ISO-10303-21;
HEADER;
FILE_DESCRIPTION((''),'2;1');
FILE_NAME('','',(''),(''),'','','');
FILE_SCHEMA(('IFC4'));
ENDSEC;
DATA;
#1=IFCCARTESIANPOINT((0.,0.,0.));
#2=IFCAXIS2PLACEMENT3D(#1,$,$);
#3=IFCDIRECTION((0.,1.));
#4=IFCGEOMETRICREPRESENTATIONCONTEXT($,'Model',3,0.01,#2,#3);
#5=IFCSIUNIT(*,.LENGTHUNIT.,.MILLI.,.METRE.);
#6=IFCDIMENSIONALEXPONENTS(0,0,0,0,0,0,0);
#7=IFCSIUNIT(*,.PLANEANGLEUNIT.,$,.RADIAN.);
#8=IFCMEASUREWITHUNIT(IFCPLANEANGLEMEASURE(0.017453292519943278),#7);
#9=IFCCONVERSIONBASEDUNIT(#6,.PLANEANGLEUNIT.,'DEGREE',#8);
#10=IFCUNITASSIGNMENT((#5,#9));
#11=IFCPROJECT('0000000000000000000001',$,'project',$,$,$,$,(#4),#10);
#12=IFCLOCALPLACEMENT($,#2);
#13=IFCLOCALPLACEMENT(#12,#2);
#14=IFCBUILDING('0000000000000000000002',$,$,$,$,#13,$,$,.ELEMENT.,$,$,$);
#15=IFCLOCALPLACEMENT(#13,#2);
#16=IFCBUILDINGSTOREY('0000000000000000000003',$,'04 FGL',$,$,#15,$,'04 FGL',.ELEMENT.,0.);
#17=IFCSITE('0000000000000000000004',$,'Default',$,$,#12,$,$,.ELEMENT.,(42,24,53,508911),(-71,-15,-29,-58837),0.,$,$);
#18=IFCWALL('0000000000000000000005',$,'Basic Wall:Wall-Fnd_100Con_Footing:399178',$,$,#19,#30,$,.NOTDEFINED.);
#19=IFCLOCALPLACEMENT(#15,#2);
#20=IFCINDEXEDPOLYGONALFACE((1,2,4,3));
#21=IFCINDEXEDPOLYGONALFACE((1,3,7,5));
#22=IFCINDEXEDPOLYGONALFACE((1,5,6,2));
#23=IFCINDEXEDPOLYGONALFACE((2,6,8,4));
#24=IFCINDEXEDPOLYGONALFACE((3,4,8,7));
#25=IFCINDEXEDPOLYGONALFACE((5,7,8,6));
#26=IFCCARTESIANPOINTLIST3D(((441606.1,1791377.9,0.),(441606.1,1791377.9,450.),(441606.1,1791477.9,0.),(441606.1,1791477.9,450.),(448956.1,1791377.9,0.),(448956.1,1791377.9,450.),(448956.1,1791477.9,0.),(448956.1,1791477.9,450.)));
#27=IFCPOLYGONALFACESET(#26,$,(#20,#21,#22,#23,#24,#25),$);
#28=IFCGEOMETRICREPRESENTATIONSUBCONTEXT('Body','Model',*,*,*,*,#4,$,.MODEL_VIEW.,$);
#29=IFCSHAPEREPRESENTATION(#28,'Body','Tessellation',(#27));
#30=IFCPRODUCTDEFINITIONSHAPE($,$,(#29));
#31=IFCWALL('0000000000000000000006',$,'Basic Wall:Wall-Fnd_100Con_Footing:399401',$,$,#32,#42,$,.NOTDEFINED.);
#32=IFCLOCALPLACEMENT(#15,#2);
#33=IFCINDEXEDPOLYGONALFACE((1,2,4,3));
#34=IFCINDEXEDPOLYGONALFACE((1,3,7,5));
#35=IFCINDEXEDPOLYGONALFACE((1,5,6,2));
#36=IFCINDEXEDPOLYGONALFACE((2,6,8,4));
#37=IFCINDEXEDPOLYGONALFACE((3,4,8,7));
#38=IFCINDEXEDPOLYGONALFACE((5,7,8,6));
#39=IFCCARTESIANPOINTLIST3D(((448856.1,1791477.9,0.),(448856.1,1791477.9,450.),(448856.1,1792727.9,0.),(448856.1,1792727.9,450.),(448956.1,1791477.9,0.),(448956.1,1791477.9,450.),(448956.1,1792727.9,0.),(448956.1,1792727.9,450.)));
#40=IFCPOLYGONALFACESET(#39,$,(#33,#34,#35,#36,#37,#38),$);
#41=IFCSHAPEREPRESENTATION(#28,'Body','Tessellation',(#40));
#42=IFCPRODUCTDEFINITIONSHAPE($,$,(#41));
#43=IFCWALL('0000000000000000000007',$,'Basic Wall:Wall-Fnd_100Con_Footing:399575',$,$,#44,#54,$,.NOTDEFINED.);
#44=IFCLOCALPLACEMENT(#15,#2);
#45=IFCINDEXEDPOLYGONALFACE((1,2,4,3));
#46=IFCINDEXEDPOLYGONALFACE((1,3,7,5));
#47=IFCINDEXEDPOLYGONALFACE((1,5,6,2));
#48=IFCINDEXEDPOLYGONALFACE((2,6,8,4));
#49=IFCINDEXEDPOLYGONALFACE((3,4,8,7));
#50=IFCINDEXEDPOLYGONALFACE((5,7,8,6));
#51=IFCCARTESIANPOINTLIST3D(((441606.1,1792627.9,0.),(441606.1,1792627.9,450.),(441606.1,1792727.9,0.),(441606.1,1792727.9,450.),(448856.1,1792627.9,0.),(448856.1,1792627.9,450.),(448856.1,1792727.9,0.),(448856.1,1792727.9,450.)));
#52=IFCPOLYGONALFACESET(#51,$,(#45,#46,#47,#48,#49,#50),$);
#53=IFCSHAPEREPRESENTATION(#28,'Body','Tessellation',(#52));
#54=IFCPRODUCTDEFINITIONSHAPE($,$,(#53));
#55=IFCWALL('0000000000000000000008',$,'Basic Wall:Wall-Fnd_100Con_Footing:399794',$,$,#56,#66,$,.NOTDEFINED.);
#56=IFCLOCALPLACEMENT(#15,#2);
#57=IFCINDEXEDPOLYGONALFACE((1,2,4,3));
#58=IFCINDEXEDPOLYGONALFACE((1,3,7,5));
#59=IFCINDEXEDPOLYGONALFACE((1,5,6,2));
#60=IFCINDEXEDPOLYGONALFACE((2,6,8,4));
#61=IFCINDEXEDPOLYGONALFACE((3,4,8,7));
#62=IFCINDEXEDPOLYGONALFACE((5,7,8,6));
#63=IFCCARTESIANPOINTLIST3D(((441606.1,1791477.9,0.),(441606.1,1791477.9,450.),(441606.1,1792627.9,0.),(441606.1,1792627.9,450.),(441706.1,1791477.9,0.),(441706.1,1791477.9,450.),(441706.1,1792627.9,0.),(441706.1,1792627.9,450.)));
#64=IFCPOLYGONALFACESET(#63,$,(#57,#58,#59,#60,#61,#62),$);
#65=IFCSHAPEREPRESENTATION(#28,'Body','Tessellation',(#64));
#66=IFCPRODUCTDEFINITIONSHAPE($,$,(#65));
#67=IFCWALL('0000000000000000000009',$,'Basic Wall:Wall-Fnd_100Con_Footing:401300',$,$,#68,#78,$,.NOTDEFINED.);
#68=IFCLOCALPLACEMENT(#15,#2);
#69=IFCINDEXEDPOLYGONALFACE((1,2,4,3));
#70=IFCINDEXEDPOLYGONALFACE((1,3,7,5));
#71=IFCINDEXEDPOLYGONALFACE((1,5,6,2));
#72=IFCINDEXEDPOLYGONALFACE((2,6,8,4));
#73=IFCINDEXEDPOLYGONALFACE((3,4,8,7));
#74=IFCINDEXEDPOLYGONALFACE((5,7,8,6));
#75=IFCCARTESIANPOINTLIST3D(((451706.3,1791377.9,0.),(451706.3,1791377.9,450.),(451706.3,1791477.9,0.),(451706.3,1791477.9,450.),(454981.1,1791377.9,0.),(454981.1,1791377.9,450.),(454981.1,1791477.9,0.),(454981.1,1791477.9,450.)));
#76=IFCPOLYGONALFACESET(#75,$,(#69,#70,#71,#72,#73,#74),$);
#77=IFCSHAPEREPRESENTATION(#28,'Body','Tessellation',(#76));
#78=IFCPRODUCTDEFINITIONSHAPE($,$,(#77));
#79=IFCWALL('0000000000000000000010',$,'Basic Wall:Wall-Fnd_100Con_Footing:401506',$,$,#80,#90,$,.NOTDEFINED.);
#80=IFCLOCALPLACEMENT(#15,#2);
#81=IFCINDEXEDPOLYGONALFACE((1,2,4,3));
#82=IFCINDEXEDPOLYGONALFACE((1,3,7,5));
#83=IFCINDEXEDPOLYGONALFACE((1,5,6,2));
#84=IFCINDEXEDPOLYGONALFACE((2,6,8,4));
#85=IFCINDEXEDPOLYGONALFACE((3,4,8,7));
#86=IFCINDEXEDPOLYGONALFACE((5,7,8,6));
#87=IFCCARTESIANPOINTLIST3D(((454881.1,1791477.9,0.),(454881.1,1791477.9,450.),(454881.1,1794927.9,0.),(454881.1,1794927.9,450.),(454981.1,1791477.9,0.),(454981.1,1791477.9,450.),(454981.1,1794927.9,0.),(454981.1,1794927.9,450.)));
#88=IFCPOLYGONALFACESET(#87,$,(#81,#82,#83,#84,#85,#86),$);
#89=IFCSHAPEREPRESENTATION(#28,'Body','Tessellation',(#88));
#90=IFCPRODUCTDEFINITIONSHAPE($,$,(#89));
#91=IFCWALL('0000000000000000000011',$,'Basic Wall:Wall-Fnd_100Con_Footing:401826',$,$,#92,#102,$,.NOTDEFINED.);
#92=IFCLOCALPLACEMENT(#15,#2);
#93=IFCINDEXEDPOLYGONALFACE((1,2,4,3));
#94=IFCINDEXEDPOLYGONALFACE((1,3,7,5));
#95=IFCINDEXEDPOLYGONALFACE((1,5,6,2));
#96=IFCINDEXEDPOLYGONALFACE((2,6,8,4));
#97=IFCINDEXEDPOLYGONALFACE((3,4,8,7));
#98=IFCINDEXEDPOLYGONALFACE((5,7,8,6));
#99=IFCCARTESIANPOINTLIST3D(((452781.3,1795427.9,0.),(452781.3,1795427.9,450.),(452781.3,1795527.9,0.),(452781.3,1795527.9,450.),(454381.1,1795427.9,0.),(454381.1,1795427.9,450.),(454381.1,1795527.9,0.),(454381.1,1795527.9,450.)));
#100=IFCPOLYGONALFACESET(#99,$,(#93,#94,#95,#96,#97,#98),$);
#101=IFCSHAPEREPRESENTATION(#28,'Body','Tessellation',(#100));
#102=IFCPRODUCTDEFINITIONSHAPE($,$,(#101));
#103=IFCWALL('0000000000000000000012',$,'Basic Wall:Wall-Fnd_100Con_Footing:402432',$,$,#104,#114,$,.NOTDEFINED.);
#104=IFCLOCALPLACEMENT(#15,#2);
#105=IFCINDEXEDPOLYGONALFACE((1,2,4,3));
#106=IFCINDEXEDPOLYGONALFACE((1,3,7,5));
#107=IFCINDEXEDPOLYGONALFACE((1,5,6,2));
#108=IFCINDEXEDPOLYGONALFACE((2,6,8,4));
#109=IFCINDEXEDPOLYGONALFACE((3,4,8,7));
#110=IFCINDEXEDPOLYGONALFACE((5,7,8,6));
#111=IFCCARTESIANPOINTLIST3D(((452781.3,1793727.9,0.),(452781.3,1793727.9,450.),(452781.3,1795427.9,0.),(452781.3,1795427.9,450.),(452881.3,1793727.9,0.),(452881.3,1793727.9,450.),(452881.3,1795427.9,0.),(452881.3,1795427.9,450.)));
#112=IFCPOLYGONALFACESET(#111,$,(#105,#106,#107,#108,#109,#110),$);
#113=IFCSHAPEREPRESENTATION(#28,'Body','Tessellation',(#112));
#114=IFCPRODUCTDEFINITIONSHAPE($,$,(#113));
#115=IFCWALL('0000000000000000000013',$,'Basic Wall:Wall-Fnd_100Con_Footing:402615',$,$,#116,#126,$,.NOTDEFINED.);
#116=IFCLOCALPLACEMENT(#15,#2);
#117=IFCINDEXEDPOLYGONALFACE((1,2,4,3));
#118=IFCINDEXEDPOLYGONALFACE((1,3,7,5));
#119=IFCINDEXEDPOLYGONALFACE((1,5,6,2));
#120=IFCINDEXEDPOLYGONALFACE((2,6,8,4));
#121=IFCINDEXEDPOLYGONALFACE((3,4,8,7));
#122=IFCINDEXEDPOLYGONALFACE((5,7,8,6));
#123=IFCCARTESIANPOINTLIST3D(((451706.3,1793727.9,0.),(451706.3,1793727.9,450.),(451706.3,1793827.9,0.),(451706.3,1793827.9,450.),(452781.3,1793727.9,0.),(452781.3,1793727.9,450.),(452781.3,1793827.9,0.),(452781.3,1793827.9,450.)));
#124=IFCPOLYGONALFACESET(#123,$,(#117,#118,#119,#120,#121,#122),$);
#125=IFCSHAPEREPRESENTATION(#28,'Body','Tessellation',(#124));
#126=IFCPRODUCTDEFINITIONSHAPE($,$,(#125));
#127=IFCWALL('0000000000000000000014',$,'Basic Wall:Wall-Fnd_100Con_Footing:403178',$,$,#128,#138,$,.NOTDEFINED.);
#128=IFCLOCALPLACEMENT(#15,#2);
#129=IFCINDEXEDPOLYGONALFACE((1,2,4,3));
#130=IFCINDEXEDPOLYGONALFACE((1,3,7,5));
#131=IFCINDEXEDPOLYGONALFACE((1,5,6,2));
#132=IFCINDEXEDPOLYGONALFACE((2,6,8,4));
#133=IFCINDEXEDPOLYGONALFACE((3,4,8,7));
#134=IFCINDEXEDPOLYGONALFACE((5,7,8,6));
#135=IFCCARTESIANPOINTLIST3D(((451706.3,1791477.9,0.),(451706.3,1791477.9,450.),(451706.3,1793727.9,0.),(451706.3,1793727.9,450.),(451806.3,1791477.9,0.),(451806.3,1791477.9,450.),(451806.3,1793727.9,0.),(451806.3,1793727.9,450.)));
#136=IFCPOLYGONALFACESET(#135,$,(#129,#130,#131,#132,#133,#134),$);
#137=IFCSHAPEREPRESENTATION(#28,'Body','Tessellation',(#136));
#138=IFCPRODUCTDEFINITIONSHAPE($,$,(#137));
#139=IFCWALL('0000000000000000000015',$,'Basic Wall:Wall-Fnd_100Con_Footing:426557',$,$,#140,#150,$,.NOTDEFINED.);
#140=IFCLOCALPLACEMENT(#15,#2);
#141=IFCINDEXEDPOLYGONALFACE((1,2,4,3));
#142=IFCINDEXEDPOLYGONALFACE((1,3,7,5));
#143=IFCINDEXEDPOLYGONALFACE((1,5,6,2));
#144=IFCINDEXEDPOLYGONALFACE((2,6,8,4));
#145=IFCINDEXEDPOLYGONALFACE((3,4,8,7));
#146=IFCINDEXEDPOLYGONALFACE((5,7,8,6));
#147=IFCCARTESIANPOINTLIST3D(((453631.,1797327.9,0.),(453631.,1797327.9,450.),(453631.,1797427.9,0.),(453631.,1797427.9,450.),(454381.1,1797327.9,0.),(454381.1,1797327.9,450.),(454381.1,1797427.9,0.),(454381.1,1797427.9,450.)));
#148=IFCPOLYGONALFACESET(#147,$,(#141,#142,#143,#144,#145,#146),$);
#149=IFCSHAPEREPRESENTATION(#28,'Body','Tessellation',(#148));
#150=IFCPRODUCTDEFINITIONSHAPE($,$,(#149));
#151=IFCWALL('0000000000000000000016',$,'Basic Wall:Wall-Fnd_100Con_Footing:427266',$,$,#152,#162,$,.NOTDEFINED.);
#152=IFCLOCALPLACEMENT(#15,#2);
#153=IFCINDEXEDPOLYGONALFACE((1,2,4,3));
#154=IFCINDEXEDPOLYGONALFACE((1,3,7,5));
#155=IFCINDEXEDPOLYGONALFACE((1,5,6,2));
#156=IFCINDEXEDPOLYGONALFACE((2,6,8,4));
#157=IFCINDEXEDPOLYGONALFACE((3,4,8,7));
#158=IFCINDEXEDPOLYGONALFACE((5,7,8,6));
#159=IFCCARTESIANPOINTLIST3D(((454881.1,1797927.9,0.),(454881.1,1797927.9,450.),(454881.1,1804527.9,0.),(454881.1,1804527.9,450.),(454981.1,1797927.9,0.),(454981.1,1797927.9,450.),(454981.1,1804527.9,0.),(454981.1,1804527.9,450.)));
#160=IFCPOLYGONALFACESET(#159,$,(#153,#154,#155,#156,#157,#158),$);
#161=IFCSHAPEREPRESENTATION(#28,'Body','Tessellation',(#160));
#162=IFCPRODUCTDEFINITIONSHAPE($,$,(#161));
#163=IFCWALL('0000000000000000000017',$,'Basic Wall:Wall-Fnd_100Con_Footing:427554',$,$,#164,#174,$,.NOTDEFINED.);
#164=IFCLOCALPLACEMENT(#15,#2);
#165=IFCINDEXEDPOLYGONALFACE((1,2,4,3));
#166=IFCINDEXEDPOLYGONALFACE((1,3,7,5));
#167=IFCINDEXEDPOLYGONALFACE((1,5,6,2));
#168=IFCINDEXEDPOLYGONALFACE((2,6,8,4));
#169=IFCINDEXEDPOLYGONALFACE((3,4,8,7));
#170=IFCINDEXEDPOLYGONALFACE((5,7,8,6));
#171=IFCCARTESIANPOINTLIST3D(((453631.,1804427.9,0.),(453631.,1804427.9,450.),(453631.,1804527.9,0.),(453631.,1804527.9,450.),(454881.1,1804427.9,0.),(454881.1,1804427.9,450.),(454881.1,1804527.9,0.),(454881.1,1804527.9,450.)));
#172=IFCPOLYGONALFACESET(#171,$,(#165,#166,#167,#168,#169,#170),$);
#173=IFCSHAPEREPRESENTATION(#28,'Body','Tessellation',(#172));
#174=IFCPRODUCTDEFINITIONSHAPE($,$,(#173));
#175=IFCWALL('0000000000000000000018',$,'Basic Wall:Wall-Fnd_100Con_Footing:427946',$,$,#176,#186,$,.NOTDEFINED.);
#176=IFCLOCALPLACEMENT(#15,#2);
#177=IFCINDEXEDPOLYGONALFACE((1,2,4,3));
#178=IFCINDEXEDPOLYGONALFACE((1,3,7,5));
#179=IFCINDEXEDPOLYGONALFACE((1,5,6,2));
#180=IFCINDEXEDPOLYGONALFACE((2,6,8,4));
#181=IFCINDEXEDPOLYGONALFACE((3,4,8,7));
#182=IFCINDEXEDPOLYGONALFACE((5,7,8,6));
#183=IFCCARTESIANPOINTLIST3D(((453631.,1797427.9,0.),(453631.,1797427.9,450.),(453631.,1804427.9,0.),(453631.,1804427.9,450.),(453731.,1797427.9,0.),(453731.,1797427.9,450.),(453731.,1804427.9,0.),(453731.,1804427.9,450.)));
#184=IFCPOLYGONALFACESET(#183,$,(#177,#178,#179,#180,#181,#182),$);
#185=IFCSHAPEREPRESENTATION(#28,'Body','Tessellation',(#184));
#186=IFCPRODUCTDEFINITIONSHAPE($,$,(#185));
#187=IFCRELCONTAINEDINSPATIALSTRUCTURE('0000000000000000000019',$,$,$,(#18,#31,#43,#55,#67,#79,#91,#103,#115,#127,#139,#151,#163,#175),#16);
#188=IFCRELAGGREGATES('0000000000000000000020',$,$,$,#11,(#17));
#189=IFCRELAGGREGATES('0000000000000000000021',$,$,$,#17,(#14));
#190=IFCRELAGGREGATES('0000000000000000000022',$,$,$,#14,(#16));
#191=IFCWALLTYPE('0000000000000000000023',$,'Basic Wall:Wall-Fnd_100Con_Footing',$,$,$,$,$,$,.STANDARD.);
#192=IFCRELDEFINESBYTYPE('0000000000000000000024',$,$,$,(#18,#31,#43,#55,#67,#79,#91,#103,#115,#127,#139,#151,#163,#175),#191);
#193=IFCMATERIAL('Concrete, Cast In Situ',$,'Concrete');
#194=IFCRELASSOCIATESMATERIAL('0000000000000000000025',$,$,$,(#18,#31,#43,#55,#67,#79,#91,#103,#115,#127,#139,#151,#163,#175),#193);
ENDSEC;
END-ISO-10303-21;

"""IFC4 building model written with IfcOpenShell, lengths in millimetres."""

from ifc_helpers import new_model, entity, si_unit, converted_unit, direction, frame, origin, place, context, subcontext, project, spatial, indexed_curve, outline, extrude, material, type_object, element, save


model = new_model("IFC4")

# Units and contexts
model_context = context("Model", 3, precision=0.01, world=origin(), true_north=direction((0.0, 1.0)))
body_context = subcontext(model_context, "Body", "Model", "MODEL_VIEW")
ifc_project = project(units=[si_unit("LENGTHUNIT", "METRE", prefix="MILLI"), converted_unit("PLANEANGLEUNIT", "DEGREE", entity("IfcPlaneAngleMeasure", 0.017453292519943278), si_unit("PLANEANGLEUNIT", "RADIAN"), dimensions=[0, 0, 0, 0, 0, 0, 0])], contexts=[model_context])

# Site, building, storey
site_placement = place(None, origin())
site = spatial("IfcSite", under=ifc_project, at=site_placement, Name="Default", CompositionType="ELEMENT", RefLatitude=(42, 24, 53, 508911), RefLongitude=(-71, -15, -29, -58837), RefElevation=0.0)
building_placement = place(site_placement, origin())
building = spatial("IfcBuilding", under=site, at=building_placement, CompositionType="ELEMENT")
storey_placement = place(building_placement, origin())
storey = spatial("IfcBuildingStorey", under=building, at=storey_placement, Name="04 FGL", LongName="04 FGL", CompositionType="ELEMENT", Elevation=0.0)

# Walls
ifc_material_1 = material(Name="Concrete, Cast In Situ", Category="Concrete")
wall_type_1 = type_object("IfcWallType", Name="Basic Wall:Wall-Fnd_100Con_Footing", PredefinedType="STANDARD")
wall_1_placement = place(storey_placement, frame((441606.1, 1791427.9, 0.0)))
element("IfcWall", 1, at=wall_1_placement, inside=storey, type_object=wall_type_1, material=ifc_material_1, Name="Basic Wall:Wall-Fnd_100Con_Footing:399178", PredefinedType="NOTDEFINED", context=body_context, shape_type="SweptSolid", body=[
    extrude(outline(indexed_curve([(7350.0, 50.0), (0.0, 50.0), (0.0, -50.0), (7350.0, -50.0), (7350.0, 50.0)], self_intersect=False)), origin(), (0.0, 0.0, 1.0), 450.0),
])
wall_2_placement = place(storey_placement, frame((448906.1, 1791477.9, 0.0), z_axis=(0.0, 0.0, 1.0), x_axis=(0.0, 1.0, 0.0)))
element("IfcWall", 2, at=wall_2_placement, inside=storey, type_object=wall_type_1, material=ifc_material_1, Name="Basic Wall:Wall-Fnd_100Con_Footing:399401", PredefinedType="NOTDEFINED", context=body_context, shape_type="SweptSolid", body=[
    extrude(outline(indexed_curve([(1250.0, 50.0), (0.0, 50.0), (0.0, -50.0), (1250.0, -50.0), (1250.0, 50.0)], self_intersect=False)), origin(), (0.0, 0.0, 1.0), 450.0),
])
wall_3_placement = place(storey_placement, frame((441606.1, 1792677.9, 0.0)))
element("IfcWall", 3, at=wall_3_placement, inside=storey, type_object=wall_type_1, material=ifc_material_1, Name="Basic Wall:Wall-Fnd_100Con_Footing:399575", PredefinedType="NOTDEFINED", context=body_context, shape_type="SweptSolid", body=[
    extrude(outline(indexed_curve([(7250.0, 50.0), (0.0, 50.0), (0.0, -50.0), (7250.0, -50.0), (7250.0, 50.0)], self_intersect=False)), origin(), (0.0, 0.0, 1.0), 450.0),
])
wall_4_placement = place(storey_placement, frame((441656.1, 1791477.9, 0.0), z_axis=(0.0, 0.0, 1.0), x_axis=(0.0, 1.0, 0.0)))
element("IfcWall", 4, at=wall_4_placement, inside=storey, type_object=wall_type_1, material=ifc_material_1, Name="Basic Wall:Wall-Fnd_100Con_Footing:399794", PredefinedType="NOTDEFINED", context=body_context, shape_type="SweptSolid", body=[
    extrude(outline(indexed_curve([(1150.0, 50.0), (0.0, 50.0), (0.0, -50.0), (1150.0, -50.0), (1150.0, 50.0)], self_intersect=False)), origin(), (0.0, 0.0, 1.0), 450.0),
])
wall_5_placement = place(storey_placement, frame((451706.3, 1791427.9, 0.0)))
element("IfcWall", 5, at=wall_5_placement, inside=storey, type_object=wall_type_1, material=ifc_material_1, Name="Basic Wall:Wall-Fnd_100Con_Footing:401300", PredefinedType="NOTDEFINED", context=body_context, shape_type="SweptSolid", body=[
    extrude(outline(indexed_curve([(3274.8, 50.0), (0.0, 50.0), (0.0, -50.0), (3274.8, -50.0), (3274.8, 50.0)], self_intersect=False)), origin(), (0.0, 0.0, 1.0), 450.0),
])
wall_6_placement = place(storey_placement, frame((454931.1, 1791477.9, 0.0), z_axis=(0.0, 0.0, 1.0), x_axis=(0.0, 1.0, 0.0)))
element("IfcWall", 6, at=wall_6_placement, inside=storey, type_object=wall_type_1, material=ifc_material_1, Name="Basic Wall:Wall-Fnd_100Con_Footing:401506", PredefinedType="NOTDEFINED", context=body_context, shape_type="SweptSolid", body=[
    extrude(outline(indexed_curve([(3450.0, 50.0), (0.0, 50.0), (0.0, -50.0), (3450.0, -50.0), (3450.0, 50.0)], self_intersect=False)), origin(), (0.0, 0.0, 1.0), 450.0),
])
wall_7_placement = place(storey_placement, frame((454381.1, 1795477.9, 0.0), z_axis=(0.0, 0.0, 1.0), x_axis=(-1.0, 0.0, 0.0)))
element("IfcWall", 7, at=wall_7_placement, inside=storey, type_object=wall_type_1, material=ifc_material_1, Name="Basic Wall:Wall-Fnd_100Con_Footing:401826", PredefinedType="NOTDEFINED", context=body_context, shape_type="SweptSolid", body=[
    extrude(outline(indexed_curve([(1599.8, 50.0), (0.0, 50.0), (0.0, -50.0), (1599.8, -50.0), (1599.8, 50.0)], self_intersect=False)), origin(), (0.0, 0.0, 1.0), 450.0),
])
wall_8_placement = place(storey_placement, frame((452831.3, 1795427.9, 0.0), z_axis=(0.0, 0.0, 1.0), x_axis=(0.0, -1.0, 0.0)))
element("IfcWall", 8, at=wall_8_placement, inside=storey, type_object=wall_type_1, material=ifc_material_1, Name="Basic Wall:Wall-Fnd_100Con_Footing:402432", PredefinedType="NOTDEFINED", context=body_context, shape_type="SweptSolid", body=[
    extrude(outline(indexed_curve([(1700.0, 50.0), (0.0, 50.0), (0.0, -50.0), (1700.0, -50.0), (1700.0, 50.0)], self_intersect=False)), origin(), (0.0, 0.0, 1.0), 450.0),
])
wall_9_placement = place(storey_placement, frame((452781.3, 1793777.9, 0.0), z_axis=(0.0, 0.0, 1.0), x_axis=(-1.0, 0.0, 0.0)))
element("IfcWall", 9, at=wall_9_placement, inside=storey, type_object=wall_type_1, material=ifc_material_1, Name="Basic Wall:Wall-Fnd_100Con_Footing:402615", PredefinedType="NOTDEFINED", context=body_context, shape_type="SweptSolid", body=[
    extrude(outline(indexed_curve([(1075.0, 50.0), (0.0, 50.0), (0.0, -50.0), (1075.0, -50.0), (1075.0, 50.0)], self_intersect=False)), origin(), (0.0, 0.0, 1.0), 450.0),
])
wall_10_placement = place(storey_placement, frame((451756.3, 1793727.9, 0.0), z_axis=(0.0, 0.0, 1.0), x_axis=(0.0, -1.0, 0.0)))
element("IfcWall", 10, at=wall_10_placement, inside=storey, type_object=wall_type_1, material=ifc_material_1, Name="Basic Wall:Wall-Fnd_100Con_Footing:403178", PredefinedType="NOTDEFINED", context=body_context, shape_type="SweptSolid", body=[
    extrude(outline(indexed_curve([(2250.0, 50.0), (0.0, 50.0), (0.0, -50.0), (2250.0, -50.0), (2250.0, 50.0)], self_intersect=False)), origin(), (0.0, 0.0, 1.0), 450.0),
])
wall_11_placement = place(storey_placement, frame((453631.0, 1797377.9, 0.0)))
element("IfcWall", 11, at=wall_11_placement, inside=storey, type_object=wall_type_1, material=ifc_material_1, Name="Basic Wall:Wall-Fnd_100Con_Footing:426557", PredefinedType="NOTDEFINED", context=body_context, shape_type="SweptSolid", body=[
    extrude(outline(indexed_curve([(750.1, 50.0), (0.0, 50.0), (0.0, -50.0), (750.1, -50.0), (750.1, 50.0)], self_intersect=False)), origin(), (0.0, 0.0, 1.0), 450.0),
])
wall_12_placement = place(storey_placement, frame((454931.1, 1797927.9, 0.0), z_axis=(0.0, 0.0, 1.0), x_axis=(0.0, 1.0, 0.0)))
element("IfcWall", 12, at=wall_12_placement, inside=storey, type_object=wall_type_1, material=ifc_material_1, Name="Basic Wall:Wall-Fnd_100Con_Footing:427266", PredefinedType="NOTDEFINED", context=body_context, shape_type="SweptSolid", body=[
    extrude(outline(indexed_curve([(6600.0, 50.0), (0.0, 50.0), (0.0, -50.0), (6600.0, -50.0), (6600.0, 50.0)], self_intersect=False)), origin(), (0.0, 0.0, 1.0), 450.0),
])
wall_13_placement = place(storey_placement, frame((454881.1, 1804477.9, 0.0), z_axis=(0.0, 0.0, 1.0), x_axis=(-1.0, 0.0, 0.0)))
element("IfcWall", 13, at=wall_13_placement, inside=storey, type_object=wall_type_1, material=ifc_material_1, Name="Basic Wall:Wall-Fnd_100Con_Footing:427554", PredefinedType="NOTDEFINED", context=body_context, shape_type="SweptSolid", body=[
    extrude(outline(indexed_curve([(1250.1, 50.0), (0.0, 50.0), (0.0, -50.0), (1250.1, -50.0), (1250.1, 50.0)], self_intersect=False)), origin(), (0.0, 0.0, 1.0), 450.0),
])
wall_14_placement = place(storey_placement, frame((453681.0, 1804427.9, 0.0), z_axis=(0.0, 0.0, 1.0), x_axis=(0.0, -1.0, 0.0)))
element("IfcWall", 14, at=wall_14_placement, inside=storey, type_object=wall_type_1, material=ifc_material_1, Name="Basic Wall:Wall-Fnd_100Con_Footing:427946", PredefinedType="NOTDEFINED", context=body_context, shape_type="SweptSolid", body=[
    extrude(outline(indexed_curve([(7000.0, 50.0), (0.0, 50.0), (0.0, -50.0), (7000.0, -50.0), (7000.0, 50.0)], self_intersect=False)), origin(), (0.0, 0.0, 1.0), 450.0),
])

save(model, "model.ifc")
